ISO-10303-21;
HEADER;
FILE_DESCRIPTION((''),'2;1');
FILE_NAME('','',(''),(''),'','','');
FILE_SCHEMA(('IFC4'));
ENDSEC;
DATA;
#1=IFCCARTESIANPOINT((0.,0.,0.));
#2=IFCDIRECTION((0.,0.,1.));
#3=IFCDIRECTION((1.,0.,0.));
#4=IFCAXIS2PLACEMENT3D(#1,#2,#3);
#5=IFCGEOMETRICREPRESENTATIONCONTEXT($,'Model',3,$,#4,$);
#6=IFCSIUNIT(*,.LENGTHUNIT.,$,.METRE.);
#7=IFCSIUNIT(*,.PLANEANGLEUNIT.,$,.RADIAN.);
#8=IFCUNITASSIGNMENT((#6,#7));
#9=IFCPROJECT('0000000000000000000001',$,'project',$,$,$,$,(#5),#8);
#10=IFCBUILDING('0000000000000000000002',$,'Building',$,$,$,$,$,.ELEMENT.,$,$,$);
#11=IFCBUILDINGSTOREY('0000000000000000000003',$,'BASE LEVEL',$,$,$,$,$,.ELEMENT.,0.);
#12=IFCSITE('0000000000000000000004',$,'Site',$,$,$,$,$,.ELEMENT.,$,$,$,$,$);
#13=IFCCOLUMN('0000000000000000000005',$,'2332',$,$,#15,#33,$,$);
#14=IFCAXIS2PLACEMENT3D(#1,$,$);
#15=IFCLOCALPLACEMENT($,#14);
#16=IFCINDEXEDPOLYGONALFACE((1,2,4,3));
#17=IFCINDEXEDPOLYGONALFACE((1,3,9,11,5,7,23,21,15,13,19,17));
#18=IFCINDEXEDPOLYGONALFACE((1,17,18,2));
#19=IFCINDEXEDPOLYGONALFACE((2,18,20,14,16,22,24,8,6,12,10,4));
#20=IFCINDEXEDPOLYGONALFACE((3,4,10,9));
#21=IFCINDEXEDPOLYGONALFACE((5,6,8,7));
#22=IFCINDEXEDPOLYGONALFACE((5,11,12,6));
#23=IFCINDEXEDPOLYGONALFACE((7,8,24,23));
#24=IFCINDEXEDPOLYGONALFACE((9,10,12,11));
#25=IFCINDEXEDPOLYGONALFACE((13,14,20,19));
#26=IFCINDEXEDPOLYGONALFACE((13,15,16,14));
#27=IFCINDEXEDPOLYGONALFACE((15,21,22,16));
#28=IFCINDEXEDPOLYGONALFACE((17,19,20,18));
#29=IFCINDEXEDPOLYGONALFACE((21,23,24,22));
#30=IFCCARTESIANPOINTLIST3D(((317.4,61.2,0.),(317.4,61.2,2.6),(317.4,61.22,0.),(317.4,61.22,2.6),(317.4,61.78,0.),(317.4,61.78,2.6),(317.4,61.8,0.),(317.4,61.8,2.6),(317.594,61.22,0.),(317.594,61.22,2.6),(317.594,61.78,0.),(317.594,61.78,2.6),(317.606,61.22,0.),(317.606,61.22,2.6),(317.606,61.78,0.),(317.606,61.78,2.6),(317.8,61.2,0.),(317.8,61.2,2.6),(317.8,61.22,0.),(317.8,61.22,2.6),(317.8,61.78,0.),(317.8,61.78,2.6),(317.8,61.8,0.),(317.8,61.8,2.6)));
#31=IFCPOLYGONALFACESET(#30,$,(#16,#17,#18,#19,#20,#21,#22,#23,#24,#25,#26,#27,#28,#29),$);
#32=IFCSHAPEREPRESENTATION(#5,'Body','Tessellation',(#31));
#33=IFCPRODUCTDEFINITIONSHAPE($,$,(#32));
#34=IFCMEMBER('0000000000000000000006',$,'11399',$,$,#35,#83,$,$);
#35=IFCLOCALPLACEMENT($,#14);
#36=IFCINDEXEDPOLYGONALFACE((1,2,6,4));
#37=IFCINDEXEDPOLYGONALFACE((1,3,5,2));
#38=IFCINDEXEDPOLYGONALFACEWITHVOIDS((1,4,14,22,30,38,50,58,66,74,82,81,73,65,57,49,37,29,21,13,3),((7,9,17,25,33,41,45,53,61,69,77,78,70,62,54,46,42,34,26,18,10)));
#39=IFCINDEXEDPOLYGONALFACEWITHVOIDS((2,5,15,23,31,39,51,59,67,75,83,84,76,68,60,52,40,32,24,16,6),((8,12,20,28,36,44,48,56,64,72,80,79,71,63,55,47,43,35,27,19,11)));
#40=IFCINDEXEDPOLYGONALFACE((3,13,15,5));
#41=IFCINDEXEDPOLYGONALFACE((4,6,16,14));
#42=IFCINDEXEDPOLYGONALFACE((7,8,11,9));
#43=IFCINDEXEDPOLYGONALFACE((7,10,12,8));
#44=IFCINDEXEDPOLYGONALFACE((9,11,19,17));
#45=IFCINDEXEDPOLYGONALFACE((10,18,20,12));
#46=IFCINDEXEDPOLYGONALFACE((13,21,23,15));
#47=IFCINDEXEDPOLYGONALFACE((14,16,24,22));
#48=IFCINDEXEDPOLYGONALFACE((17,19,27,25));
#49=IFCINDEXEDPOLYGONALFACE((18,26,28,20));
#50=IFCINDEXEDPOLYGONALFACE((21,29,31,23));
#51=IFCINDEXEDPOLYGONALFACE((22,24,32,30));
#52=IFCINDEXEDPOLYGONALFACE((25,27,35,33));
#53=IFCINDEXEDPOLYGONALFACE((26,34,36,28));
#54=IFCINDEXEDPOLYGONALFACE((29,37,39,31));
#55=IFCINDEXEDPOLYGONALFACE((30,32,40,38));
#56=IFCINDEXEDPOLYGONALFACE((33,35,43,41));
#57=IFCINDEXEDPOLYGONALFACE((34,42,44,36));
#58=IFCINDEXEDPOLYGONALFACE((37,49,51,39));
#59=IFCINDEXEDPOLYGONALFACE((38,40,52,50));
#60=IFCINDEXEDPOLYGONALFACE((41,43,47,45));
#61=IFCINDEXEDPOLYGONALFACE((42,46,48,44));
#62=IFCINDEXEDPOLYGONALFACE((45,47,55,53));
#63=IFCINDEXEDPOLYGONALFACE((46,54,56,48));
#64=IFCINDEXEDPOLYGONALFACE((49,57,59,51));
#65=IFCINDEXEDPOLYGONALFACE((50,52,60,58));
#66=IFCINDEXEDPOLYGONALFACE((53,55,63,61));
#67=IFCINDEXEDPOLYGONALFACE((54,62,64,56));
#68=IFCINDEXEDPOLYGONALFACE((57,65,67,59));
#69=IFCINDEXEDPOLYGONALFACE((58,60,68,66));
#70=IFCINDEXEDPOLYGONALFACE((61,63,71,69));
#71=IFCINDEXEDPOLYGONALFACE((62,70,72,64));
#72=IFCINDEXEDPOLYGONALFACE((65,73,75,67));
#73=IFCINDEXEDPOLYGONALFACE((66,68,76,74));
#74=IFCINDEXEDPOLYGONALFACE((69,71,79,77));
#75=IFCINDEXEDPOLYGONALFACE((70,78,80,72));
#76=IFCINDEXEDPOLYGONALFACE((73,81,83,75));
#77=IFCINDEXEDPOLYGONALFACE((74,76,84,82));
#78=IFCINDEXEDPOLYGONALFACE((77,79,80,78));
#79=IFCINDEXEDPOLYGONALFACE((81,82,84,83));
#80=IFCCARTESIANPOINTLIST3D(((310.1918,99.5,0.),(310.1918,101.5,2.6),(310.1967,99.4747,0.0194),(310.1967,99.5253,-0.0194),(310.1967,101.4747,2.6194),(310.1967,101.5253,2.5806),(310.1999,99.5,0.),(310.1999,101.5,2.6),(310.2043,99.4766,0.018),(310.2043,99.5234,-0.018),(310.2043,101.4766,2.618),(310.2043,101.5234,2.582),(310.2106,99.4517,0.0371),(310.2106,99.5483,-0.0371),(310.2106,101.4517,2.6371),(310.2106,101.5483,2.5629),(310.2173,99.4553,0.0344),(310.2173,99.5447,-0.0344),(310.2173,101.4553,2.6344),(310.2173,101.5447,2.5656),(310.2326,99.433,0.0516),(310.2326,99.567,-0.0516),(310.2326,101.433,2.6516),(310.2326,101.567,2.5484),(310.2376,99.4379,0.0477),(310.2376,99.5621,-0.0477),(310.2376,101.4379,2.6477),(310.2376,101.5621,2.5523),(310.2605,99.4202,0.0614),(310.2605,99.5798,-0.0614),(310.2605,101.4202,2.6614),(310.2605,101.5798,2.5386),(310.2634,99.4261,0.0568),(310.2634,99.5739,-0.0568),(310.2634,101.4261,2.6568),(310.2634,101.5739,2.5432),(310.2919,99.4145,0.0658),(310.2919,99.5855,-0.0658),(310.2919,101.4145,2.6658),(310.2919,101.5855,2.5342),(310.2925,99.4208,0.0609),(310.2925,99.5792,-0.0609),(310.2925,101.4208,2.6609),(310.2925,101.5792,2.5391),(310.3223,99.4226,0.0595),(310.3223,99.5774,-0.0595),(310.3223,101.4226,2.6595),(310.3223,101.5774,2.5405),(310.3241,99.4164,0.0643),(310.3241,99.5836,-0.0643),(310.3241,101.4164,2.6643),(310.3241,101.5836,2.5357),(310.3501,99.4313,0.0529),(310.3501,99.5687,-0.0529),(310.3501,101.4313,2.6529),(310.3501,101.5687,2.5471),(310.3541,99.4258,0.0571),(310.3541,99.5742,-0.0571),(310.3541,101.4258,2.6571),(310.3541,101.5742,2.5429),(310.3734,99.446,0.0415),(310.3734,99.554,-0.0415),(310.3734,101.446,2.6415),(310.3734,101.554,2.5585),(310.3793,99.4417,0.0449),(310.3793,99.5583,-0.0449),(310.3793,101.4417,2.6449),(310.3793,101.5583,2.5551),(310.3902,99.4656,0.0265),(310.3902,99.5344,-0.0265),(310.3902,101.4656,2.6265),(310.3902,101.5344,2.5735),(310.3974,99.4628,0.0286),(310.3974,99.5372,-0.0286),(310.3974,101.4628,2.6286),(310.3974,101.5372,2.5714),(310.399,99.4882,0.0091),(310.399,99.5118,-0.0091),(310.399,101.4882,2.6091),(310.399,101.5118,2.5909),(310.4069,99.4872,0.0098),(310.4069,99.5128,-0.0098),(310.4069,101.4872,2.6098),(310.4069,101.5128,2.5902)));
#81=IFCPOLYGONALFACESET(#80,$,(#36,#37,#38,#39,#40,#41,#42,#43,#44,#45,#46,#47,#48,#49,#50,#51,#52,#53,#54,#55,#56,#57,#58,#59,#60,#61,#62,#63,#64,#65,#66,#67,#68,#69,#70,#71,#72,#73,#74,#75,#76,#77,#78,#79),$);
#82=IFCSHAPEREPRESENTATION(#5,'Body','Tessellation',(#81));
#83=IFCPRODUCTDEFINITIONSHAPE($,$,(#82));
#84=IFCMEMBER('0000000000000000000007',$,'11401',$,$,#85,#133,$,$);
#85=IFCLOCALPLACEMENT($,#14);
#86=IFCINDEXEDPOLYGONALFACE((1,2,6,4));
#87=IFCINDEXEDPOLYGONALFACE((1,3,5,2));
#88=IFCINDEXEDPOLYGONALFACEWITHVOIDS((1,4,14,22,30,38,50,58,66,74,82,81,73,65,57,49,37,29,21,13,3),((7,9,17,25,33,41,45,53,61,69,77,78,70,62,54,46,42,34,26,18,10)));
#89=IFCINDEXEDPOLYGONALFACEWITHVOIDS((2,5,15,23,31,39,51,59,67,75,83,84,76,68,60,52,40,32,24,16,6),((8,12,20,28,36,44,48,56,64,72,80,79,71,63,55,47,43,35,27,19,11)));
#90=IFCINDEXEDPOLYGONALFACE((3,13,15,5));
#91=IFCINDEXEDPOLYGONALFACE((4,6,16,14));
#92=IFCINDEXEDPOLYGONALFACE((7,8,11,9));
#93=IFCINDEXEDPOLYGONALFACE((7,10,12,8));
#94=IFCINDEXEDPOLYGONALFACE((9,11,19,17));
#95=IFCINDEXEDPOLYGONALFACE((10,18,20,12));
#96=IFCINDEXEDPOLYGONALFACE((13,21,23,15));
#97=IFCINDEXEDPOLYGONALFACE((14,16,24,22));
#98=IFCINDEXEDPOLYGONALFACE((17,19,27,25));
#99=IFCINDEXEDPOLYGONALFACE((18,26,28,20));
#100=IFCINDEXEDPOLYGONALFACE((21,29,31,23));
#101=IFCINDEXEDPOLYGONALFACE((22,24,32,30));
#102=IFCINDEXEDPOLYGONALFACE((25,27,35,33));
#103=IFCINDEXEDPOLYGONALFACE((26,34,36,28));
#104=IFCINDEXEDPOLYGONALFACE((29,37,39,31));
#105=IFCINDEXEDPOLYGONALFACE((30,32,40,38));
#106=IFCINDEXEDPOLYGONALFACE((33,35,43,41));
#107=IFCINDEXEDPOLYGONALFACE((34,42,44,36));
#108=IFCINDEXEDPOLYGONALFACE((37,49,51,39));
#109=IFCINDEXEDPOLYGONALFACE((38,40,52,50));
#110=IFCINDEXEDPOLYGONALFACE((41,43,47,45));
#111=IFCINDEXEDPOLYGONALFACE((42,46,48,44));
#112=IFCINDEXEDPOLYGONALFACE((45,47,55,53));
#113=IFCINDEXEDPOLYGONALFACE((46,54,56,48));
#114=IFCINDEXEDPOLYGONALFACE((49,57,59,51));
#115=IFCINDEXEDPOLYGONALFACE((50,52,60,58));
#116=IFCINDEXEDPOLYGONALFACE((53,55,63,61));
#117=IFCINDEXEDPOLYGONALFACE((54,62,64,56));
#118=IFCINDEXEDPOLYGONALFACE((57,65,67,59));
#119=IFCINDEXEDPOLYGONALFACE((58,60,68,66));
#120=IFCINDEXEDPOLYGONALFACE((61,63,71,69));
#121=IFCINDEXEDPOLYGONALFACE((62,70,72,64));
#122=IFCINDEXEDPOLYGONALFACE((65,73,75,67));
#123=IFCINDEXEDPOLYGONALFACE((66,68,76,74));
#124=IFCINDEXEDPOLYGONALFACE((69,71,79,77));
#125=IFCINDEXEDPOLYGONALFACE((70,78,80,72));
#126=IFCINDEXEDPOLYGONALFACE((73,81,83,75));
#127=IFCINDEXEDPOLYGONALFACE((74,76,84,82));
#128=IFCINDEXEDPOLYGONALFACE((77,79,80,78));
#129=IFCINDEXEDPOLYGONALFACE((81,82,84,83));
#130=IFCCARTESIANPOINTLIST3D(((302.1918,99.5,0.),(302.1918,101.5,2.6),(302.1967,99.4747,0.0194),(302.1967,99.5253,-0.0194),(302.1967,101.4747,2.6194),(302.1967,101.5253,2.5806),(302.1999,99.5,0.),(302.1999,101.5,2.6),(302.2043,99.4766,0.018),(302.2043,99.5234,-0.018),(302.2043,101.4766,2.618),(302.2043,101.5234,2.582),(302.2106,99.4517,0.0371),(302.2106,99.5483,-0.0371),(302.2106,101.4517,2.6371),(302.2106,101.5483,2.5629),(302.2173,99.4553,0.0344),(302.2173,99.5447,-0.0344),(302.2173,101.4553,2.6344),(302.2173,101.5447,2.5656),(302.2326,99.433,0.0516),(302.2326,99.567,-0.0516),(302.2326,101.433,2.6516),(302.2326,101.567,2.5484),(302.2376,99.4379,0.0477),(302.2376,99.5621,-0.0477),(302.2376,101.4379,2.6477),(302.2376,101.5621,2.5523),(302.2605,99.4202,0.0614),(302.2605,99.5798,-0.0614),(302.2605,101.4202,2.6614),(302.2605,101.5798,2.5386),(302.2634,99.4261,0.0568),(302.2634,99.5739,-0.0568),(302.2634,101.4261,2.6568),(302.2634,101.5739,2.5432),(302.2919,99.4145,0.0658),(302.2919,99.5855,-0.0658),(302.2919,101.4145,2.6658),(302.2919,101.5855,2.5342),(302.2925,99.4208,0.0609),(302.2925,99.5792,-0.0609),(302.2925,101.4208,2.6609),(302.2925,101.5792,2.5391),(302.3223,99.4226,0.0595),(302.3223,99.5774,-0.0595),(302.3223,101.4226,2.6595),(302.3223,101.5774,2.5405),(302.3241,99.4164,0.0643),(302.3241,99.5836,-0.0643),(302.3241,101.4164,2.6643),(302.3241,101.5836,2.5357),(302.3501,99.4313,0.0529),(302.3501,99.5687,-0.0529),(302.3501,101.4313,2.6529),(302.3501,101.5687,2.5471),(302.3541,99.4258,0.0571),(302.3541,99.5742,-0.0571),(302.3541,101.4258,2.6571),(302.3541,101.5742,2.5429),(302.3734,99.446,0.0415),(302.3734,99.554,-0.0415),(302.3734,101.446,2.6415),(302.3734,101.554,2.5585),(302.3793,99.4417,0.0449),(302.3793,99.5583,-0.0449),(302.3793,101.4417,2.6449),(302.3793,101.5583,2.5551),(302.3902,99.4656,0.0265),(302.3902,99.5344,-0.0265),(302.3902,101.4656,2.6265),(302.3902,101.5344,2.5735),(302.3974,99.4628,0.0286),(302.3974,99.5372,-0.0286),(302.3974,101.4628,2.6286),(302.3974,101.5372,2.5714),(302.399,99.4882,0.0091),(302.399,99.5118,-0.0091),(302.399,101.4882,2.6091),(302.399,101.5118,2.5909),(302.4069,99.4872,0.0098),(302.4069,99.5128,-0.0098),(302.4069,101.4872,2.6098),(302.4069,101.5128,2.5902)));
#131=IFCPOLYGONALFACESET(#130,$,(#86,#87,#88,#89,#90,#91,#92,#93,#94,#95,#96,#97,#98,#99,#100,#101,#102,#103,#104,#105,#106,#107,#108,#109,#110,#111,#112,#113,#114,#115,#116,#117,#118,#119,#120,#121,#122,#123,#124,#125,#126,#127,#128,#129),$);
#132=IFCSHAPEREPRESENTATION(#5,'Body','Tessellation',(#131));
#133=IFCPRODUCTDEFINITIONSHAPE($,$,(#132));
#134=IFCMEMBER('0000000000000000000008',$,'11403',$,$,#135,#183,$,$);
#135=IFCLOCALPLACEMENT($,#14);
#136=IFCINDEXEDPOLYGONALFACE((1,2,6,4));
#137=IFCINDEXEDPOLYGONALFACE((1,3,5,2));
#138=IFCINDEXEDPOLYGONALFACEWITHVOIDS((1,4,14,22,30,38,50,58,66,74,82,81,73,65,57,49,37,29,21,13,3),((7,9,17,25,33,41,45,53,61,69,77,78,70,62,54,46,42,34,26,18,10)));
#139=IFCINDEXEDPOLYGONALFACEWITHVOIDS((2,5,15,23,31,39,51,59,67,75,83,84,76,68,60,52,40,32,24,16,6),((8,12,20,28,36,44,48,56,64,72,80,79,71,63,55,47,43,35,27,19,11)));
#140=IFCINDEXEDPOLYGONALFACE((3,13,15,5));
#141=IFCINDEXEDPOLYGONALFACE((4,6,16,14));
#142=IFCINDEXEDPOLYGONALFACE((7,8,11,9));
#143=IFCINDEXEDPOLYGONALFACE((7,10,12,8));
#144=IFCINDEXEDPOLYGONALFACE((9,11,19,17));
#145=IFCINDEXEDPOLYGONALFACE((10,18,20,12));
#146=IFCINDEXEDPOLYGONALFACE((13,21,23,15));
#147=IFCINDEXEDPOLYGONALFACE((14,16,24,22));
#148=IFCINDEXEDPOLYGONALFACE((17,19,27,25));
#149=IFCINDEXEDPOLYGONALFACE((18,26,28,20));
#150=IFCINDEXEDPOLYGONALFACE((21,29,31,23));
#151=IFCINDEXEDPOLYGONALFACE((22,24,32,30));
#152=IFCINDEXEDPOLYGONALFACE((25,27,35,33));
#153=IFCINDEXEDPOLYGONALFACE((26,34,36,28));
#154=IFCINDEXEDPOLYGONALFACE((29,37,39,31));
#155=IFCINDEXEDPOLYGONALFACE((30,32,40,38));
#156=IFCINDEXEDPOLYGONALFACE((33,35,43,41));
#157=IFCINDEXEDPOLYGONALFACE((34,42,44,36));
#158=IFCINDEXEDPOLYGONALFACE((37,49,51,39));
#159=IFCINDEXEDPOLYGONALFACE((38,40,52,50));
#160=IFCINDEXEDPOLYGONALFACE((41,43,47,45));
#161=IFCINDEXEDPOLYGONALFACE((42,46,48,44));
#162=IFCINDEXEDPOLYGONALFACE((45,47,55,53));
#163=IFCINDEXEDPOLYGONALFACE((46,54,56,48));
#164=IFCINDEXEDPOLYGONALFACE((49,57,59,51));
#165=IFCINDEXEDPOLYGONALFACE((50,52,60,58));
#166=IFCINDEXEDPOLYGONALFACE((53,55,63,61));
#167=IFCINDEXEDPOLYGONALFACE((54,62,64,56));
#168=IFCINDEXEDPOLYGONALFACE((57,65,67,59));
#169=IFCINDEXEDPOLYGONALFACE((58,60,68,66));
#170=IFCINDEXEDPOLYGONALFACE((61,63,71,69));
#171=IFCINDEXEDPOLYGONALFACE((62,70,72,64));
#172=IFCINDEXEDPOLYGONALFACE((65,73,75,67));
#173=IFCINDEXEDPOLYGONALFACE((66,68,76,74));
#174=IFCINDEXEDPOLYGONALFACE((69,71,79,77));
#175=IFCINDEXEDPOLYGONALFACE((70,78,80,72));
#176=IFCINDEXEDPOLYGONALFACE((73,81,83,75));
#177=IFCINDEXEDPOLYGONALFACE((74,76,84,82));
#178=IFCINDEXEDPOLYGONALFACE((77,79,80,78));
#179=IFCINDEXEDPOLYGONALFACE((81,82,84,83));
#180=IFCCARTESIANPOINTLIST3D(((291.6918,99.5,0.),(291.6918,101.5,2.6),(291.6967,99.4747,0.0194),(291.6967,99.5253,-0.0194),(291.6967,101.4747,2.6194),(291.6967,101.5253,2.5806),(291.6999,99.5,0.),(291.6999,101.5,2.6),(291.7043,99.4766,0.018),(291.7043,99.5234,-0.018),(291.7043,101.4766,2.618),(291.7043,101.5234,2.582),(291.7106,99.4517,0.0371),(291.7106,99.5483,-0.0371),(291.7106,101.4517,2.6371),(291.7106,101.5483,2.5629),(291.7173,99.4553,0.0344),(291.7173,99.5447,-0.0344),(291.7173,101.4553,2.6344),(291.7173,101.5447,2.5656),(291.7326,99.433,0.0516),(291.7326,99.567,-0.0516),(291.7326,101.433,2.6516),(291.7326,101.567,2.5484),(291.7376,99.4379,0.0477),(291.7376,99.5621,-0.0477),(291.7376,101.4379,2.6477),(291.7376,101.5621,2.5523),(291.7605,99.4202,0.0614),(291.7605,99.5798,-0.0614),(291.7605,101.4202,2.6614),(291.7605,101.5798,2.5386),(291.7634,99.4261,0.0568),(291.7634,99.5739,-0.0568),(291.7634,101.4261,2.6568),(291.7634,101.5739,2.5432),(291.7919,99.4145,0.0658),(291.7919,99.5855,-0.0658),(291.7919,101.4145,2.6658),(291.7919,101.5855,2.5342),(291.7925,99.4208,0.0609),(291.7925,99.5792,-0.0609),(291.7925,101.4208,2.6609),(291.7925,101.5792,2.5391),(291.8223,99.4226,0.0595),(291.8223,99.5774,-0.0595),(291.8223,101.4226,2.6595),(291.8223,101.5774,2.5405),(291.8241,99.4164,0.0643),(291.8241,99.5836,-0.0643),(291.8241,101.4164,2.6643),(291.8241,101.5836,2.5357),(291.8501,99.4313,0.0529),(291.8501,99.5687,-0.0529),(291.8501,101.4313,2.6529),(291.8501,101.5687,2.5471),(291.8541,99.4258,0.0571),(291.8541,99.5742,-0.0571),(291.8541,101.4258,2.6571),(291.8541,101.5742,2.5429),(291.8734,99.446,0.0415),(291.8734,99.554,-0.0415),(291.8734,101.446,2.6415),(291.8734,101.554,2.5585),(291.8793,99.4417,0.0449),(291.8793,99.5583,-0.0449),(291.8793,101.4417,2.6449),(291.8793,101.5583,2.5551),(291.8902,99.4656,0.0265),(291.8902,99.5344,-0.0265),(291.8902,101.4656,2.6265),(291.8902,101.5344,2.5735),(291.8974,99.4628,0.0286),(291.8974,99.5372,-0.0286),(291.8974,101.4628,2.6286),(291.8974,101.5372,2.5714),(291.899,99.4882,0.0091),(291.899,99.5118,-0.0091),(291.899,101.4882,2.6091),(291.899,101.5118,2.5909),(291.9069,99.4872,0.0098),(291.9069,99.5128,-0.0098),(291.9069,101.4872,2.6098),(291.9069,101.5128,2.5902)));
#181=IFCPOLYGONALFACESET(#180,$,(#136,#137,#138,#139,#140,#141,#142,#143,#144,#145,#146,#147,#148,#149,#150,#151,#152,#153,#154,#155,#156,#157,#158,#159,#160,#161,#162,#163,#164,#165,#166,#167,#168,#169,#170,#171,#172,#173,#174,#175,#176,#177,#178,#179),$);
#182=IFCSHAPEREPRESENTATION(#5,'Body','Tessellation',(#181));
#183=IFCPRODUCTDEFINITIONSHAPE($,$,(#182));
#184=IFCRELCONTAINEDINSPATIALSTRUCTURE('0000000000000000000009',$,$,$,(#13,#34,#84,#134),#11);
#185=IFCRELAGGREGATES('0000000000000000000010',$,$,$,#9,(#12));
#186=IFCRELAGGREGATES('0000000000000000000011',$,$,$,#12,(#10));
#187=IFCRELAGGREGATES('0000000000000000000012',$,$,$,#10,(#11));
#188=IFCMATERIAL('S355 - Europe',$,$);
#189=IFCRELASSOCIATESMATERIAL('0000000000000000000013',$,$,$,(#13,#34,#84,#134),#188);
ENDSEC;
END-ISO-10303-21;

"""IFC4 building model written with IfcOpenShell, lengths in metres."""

from ifc_helpers import new_model, si_unit, frame, origin_with_axes, origin_2d_with_axis, place, context, project, spatial, hollow_circle, i_section, extrude, material, material_profile, profile_set, profile_usage, element, save


model = new_model("IFC4")

# Units and contexts
model_context = context("Model", 3, world=origin_with_axes())
ifc_project = project(units=[si_unit("LENGTHUNIT", "METRE"), si_unit("PLANEANGLEUNIT", "RADIAN")], contexts=[model_context])

# Site, building, storey
site = spatial("IfcSite", under=ifc_project, Name="Site", CompositionType="ELEMENT")
building = spatial("IfcBuilding", under=site, Name="Building", CompositionType="ELEMENT")
storey = spatial("IfcBuildingStorey", under=building, Name="BASE LEVEL", CompositionType="ELEMENT", Elevation=0.0)

# Column
ifc_material = material(Name="S355 - Europe")
ifc_material_profile_1 = material_profile(ifc_material, i_section(OverallWidth=0.4, OverallDepth=0.6, WebThickness=0.012, FlangeThickness=0.02, at=origin_2d_with_axis()))
ifc_profile_set_1 = profile_set([ifc_material_profile_1])
ifc_profile_usage_1 = profile_usage(ifc_profile_set_1, cardinal=10)
column_1_placement = place(None, frame((317.6, 61.5, 0.0), z_axis=(0.0, 0.0, 1.0), x_axis=(1.0, 0.0, 0.0)))
element("IfcColumn", 1, at=column_1_placement, inside=storey, material=ifc_profile_usage_1, Name="2332", context=model_context, shape_type="SweptSolid", body=[
    extrude(i_section(OverallWidth=0.4, OverallDepth=0.6, WebThickness=0.012, FlangeThickness=0.02, at=origin_2d_with_axis()), origin_with_axes(), (0.0, 0.0, 1.0), 2.6),
])

# Members
ifc_material_profile_2 = material_profile(ifc_material, hollow_circle(Radius=0.1081, WallThickness=0.008, at=origin_2d_with_axis()))
ifc_profile_set_2 = profile_set([ifc_material_profile_2])
ifc_profile_usage_2 = profile_usage(ifc_profile_set_2, cardinal=10)
member_1_placement = place(None, frame((310.3, 99.5, 0.0), z_axis=(0.0, 0.609711, 0.792624), x_axis=(-1.0, 0.0, 0.0)))
element("IfcMember", 2, at=member_1_placement, inside=storey, material=ifc_profile_usage_2, Name="11399", context=model_context, shape_type="SweptSolid", body=[
    extrude(hollow_circle(Radius=0.1081, WallThickness=0.008, at=origin_2d_with_axis()), origin_with_axes(), (0.0, 0.0, 1.0), 3.2802),
])
ifc_material_profile_3 = material_profile(ifc_material, hollow_circle(Radius=0.1081, WallThickness=0.008, at=origin_2d_with_axis()))
ifc_profile_set_3 = profile_set([ifc_material_profile_3])
ifc_profile_usage_3 = profile_usage(ifc_profile_set_3, cardinal=10)
member_2_placement = place(None, frame((302.3, 99.5, 0.0), z_axis=(0.0, 0.609711, 0.792624), x_axis=(-1.0, 0.0, 0.0)))
element("IfcMember", 3, at=member_2_placement, inside=storey, material=ifc_profile_usage_3, Name="11401", context=model_context, shape_type="SweptSolid", body=[
    extrude(hollow_circle(Radius=0.1081, WallThickness=0.008, at=origin_2d_with_axis()), origin_with_axes(), (0.0, 0.0, 1.0), 3.2802),
])
ifc_material_profile_4 = material_profile(ifc_material, hollow_circle(Radius=0.1081, WallThickness=0.008, at=origin_2d_with_axis()))
ifc_profile_set_4 = profile_set([ifc_material_profile_4])
ifc_profile_usage_4 = profile_usage(ifc_profile_set_4, cardinal=10)
member_3_placement = place(None, frame((291.8, 99.5, 0.0), z_axis=(0.0, 0.609711, 0.792624), x_axis=(-1.0, 0.0, 0.0)))
element("IfcMember", 4, at=member_3_placement, inside=storey, material=ifc_profile_usage_4, Name="11403", context=model_context, shape_type="SweptSolid", body=[
    extrude(hollow_circle(Radius=0.1081, WallThickness=0.008, at=origin_2d_with_axis()), origin_with_axes(), (0.0, 0.0, 1.0), 3.2802),
])

save(model, "model.ifc")
